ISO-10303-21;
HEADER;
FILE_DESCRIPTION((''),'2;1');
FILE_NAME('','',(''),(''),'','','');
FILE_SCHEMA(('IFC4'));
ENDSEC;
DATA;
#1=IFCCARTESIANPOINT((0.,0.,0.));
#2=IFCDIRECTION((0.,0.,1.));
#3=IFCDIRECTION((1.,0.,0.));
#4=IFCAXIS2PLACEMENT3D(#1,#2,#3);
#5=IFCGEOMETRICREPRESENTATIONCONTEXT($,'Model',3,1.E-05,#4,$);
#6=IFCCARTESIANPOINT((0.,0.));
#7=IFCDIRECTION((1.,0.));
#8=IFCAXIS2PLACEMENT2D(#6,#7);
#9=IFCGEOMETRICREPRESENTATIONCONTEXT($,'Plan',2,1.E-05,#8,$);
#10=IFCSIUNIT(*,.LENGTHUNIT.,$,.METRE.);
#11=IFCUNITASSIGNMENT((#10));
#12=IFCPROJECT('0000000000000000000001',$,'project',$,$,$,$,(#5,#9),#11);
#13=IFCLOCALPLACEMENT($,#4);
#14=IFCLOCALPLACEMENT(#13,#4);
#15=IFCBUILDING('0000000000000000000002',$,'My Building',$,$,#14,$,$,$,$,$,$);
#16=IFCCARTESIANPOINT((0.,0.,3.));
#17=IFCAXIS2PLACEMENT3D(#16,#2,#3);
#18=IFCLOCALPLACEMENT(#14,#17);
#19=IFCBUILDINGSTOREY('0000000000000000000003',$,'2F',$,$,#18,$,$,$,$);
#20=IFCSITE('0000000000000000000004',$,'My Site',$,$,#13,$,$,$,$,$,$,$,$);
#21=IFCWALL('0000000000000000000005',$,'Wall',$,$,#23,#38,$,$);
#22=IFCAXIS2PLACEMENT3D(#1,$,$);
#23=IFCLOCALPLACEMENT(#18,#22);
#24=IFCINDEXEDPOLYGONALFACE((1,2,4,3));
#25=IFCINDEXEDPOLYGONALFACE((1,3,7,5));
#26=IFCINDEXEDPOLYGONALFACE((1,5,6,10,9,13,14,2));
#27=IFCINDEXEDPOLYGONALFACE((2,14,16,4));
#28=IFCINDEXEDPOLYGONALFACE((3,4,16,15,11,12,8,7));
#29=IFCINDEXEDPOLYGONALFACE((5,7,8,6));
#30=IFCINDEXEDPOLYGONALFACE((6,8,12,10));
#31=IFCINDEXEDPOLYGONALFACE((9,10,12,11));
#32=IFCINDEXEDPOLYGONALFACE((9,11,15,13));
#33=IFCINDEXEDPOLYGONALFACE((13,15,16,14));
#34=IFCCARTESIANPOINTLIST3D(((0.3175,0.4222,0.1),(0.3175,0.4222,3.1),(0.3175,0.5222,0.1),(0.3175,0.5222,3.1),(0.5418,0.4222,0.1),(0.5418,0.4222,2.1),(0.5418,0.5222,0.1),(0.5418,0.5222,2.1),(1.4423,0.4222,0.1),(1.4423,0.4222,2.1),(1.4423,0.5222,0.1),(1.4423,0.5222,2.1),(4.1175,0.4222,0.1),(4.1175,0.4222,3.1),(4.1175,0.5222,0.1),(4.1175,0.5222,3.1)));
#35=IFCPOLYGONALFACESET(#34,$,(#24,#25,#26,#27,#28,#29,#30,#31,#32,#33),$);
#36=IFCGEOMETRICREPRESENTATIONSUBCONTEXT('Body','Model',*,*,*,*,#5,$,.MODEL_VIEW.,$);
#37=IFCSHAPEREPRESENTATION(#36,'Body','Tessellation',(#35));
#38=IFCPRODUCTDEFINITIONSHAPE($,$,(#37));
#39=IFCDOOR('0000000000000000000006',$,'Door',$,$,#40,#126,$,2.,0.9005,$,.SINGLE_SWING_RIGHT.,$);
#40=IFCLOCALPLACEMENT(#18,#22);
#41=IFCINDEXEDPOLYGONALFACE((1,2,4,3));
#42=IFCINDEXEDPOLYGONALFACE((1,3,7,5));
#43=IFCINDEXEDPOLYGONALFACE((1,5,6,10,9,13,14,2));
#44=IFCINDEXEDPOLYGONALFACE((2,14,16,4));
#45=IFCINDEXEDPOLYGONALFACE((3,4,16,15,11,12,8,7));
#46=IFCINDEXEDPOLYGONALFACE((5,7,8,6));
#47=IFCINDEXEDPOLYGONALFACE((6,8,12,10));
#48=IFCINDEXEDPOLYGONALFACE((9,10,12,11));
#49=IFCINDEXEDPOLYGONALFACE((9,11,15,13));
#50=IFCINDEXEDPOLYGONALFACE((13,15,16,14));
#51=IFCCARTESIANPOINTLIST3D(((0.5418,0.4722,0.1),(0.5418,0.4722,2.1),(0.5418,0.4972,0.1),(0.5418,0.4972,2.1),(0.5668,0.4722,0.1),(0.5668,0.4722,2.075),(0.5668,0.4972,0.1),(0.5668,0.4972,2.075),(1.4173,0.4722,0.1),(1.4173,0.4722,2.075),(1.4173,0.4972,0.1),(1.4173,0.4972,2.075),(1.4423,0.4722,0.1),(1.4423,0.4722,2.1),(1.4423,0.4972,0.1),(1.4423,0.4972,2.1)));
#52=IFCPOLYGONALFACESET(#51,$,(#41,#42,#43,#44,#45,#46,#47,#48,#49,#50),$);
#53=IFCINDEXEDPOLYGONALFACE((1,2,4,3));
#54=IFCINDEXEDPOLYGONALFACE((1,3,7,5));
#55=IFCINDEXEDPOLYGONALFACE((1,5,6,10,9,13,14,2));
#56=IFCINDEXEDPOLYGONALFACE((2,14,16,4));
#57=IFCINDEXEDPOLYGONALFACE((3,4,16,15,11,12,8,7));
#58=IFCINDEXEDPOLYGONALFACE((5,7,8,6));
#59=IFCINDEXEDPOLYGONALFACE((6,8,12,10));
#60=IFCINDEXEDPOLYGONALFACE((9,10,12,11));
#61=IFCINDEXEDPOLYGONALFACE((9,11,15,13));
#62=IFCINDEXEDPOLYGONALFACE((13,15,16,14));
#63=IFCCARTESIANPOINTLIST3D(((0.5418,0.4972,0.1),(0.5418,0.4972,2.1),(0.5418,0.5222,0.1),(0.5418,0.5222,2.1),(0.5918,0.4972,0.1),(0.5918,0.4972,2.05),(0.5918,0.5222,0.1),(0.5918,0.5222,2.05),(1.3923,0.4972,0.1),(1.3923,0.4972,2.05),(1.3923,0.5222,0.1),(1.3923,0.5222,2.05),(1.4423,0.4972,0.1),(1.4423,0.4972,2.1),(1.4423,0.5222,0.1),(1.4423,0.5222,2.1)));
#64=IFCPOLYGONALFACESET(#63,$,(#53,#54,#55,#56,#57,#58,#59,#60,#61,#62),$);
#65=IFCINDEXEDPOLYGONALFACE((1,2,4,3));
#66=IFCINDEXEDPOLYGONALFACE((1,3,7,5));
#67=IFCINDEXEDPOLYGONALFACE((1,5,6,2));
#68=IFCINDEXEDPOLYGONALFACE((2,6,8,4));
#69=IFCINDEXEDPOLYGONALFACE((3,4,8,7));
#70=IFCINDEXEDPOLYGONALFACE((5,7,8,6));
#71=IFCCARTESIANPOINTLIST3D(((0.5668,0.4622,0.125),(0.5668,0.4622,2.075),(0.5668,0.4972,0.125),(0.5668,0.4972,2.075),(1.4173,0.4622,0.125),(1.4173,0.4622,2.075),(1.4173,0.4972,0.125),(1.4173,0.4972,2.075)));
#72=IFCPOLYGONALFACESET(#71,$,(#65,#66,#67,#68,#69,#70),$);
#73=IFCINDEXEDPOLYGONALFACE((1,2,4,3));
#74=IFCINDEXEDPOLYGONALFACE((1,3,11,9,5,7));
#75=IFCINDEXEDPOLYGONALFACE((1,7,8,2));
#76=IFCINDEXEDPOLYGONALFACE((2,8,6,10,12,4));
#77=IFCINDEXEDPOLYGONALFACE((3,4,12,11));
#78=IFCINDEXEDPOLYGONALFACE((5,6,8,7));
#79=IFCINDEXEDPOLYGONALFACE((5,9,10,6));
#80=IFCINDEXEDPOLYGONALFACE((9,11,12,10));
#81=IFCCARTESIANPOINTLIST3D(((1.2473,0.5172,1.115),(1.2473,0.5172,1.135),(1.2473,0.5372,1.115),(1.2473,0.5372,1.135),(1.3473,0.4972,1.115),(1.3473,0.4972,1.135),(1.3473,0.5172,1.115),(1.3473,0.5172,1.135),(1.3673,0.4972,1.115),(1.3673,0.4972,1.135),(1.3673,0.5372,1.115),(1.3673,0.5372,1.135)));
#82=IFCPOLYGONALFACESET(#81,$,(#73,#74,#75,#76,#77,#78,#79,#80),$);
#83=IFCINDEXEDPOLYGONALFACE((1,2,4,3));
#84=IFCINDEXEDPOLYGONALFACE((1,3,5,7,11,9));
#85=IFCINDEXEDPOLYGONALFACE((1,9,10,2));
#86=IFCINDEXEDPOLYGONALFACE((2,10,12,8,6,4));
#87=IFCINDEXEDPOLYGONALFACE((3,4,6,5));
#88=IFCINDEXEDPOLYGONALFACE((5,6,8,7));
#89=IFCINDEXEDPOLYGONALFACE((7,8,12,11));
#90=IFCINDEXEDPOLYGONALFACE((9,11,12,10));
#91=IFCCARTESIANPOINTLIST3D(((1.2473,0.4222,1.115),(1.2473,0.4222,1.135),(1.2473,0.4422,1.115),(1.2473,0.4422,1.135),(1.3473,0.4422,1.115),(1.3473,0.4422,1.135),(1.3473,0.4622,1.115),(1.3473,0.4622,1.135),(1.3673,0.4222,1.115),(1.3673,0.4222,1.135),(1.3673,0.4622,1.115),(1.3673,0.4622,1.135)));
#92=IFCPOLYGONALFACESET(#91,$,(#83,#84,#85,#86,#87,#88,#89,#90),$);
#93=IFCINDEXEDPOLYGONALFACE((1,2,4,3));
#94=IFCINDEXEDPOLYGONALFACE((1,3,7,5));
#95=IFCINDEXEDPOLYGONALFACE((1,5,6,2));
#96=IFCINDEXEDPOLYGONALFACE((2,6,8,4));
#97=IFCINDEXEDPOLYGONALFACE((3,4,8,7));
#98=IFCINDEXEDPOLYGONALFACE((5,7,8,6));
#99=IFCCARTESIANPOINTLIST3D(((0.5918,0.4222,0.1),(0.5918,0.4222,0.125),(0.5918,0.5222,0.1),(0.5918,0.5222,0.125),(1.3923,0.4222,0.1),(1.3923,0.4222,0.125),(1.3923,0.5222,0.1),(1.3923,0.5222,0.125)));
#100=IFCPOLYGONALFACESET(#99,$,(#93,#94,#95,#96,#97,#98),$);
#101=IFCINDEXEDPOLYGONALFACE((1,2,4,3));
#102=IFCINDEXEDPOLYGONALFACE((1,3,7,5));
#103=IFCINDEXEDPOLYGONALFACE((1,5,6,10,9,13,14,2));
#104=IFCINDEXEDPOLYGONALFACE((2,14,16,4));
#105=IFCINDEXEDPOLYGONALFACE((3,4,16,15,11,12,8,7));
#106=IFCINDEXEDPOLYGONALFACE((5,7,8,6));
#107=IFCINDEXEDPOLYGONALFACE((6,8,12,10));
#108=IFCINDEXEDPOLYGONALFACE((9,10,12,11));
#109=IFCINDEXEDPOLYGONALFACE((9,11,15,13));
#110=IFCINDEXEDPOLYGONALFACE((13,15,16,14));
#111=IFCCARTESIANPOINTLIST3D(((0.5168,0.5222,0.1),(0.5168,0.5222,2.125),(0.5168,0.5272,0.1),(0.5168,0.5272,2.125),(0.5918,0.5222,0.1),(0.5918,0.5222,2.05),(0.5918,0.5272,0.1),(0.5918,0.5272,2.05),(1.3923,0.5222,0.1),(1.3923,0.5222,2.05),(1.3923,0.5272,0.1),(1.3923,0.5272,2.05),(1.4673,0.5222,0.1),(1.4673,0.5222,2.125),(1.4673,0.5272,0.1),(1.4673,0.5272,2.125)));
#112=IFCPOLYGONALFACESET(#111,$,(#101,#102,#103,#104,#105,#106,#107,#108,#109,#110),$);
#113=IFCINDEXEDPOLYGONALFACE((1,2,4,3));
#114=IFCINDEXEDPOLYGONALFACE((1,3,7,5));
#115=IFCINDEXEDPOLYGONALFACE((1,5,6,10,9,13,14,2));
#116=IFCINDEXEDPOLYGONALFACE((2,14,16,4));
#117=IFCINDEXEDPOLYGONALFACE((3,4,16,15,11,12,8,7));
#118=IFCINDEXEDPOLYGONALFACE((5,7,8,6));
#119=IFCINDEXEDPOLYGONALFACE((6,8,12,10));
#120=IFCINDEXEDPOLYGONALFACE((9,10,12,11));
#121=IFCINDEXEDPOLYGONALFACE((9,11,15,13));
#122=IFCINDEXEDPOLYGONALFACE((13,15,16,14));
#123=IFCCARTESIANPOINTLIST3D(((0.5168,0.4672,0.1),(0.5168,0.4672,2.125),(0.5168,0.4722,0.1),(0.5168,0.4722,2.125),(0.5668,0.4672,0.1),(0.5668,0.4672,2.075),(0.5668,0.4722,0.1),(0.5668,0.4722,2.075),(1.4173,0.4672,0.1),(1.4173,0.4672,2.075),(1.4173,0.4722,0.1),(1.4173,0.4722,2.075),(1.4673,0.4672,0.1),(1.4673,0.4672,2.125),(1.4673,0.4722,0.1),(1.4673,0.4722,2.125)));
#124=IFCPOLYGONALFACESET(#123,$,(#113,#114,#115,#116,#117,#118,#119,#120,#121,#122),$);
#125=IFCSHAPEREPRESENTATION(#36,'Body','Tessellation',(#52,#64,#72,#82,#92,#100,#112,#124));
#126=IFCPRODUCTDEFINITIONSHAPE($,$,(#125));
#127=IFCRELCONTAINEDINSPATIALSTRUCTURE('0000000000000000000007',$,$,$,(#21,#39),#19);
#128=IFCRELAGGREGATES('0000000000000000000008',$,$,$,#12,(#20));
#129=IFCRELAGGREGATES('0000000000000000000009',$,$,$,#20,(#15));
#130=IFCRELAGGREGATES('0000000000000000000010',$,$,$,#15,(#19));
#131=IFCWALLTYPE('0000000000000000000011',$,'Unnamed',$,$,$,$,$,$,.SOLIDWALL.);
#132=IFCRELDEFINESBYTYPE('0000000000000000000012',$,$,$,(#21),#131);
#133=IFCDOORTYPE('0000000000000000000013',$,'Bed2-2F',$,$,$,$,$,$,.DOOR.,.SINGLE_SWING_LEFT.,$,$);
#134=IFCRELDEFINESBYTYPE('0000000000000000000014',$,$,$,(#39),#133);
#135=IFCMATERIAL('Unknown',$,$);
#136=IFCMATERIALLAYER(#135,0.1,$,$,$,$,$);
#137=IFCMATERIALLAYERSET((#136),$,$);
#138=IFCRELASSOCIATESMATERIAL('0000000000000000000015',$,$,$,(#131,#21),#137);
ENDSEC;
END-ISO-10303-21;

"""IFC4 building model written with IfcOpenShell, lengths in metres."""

from ifc_helpers import new_model, entity, si_unit, frame, origin_with_axes, origin_2d_with_axis, place, context, subcontext, project, spatial, line, indexed_curve, outline, extrude, shape, source, transform, mapped, material, layer, layer_set, layer_usage, type_object, type_shapes, element, fill, save


model = new_model("IFC4")

# Units and contexts
model_context = context("Model", 3, precision=1e-05, world=origin_with_axes())
plan_context = context("Plan", 2, precision=1e-05, world=origin_2d_with_axis())
body_context_1 = subcontext(model_context, "Body", "Model", "MODEL_VIEW")
body_context_2 = subcontext(plan_context, "Body", "Plan", "PLAN_VIEW")
ifc_project = project(units=[si_unit("LENGTHUNIT", "METRE")], contexts=[model_context, plan_context])

# Site, building, storey
site_placement = place(None, origin_with_axes())
site = spatial("IfcSite", under=ifc_project, at=site_placement, Name="My Site")
building_placement = place(site_placement, origin_with_axes())
building = spatial("IfcBuilding", under=site, at=building_placement, Name="My Building")
storey_placement = place(building_placement, frame((0.0, 0.0, 3.0), z_axis=(0.0, 0.0, 1.0), x_axis=(1.0, 0.0, 0.0)))
storey = spatial("IfcBuildingStorey", under=building, at=storey_placement, Name="2F")

# Shared definitions
ifc_material = material(Name="Unknown")
ifc_layer = layer(ifc_material, 0.1)
ifc_layer_set = layer_set([ifc_layer])
wall_type = type_object("IfcWallType", Name="Unnamed", PredefinedType="SOLIDWALL", material=ifc_layer_set)

# Wall, opening, door
ifc_layer_usage_1 = layer_usage(ifc_layer_set, "AXIS2", "POSITIVE", 0.0)
wall_1_placement = place(storey_placement, frame((0.2175, 0.4222, 0.1), z_axis=(0.0, 0.0, 1.0), x_axis=(1.0, 0.0, 0.0)))
wall_1 = element("IfcWall", 1, at=wall_1_placement, inside=storey, type_object=wall_type, material=ifc_layer_usage_1, Name="Wall", context=body_context_1, shape_type="SweptSolid", body=[
    extrude(outline(indexed_curve([(0.1, 0.0), (0.1, 0.1), (3.9, 0.1), (3.9, 0.0)], segments=[line(1, 2, 3, 4, 1)])), origin_with_axes(), (0.0, 0.0, 1.0), 3.0),
])
shared_shape_1 = source(origin_with_axes(), body_context_1, "Body", "SweptSolid", [
    extrude(outline(indexed_curve([(0.0, 0.0), (0.9005, 0.0), (0.9005, 2.0), (0.0, 2.0)], segments=[line(1, 2, 3, 4, 1)])), frame((0.0, -0.6, 0.0), z_axis=(0.0, -1.0, 0.0), x_axis=(1.0, 0.0, 0.0)), (0.0, 0.0, -1.0), 1.2),
])
opening_1_placement = place(wall_1_placement, frame((1.2248, 0.1, 0.0), z_axis=(0.0, 0.0, 1.0), x_axis=(-1.0, 0.0, 0.0)))
opening_1 = element("IfcOpeningElement", 2, at=opening_1_placement, cuts=wall_1, PredefinedType="OPENING", context=body_context_1, shape_type="MappedRepresentation", body=[
    mapped(shared_shape_1, transform((0.0, 0.0, 0.0), x_axis=(1.0, 0.0, 0.0), y_axis=(0.0, 1.0, 0.0), z_axis=(0.0, 0.0, 1.0), scale=1.0)),
])
door_type_1 = type_object("IfcDoorType", Name="Bed2-2F", OperationType="SINGLE_SWING_LEFT", PredefinedType="DOOR")
shared_shape_2 = source(origin_with_axes(), body_context_1, "Body", "SweptSolid", [
    extrude(outline(indexed_curve([(0.0, 0.0), (0.0, 2.0), (0.9005, 2.0), (0.9005, 0.0), (0.8755, 0.0), (0.8755, 1.975), (0.025, 1.975), (0.025, 0.0)], segments=[line(1, 2, 3, 4, 5, 6, 7, 8, 1)])), frame((0.0, 0.025, 0.0), z_axis=(0.0, -1.0, 0.0), x_axis=(1.0, 0.0, 0.0)), (0.0, 0.0, -1.0), 0.025),
    extrude(outline(indexed_curve([(0.0, 0.0), (0.0, 2.0), (0.9005, 2.0), (0.9005, 0.0), (0.8505, 0.0), (0.8505, 1.95), (0.05, 1.95), (0.05, 0.0)], segments=[line(1, 2, 3, 4, 5, 6, 7, 8, 1)])), frame((0.0, 0.0, 0.0), z_axis=(0.0, -1.0, 0.0), x_axis=(1.0, 0.0, 0.0)), (0.0, 0.0, -1.0), 0.025),
    extrude(outline(indexed_curve([(0.0, 0.0), (0.8505, 0.0), (0.8505, 0.035), (0.0, 0.035)], segments=[line(1, 2, 3, 4, 1)])), frame((0.025, 0.025, 0.025), z_axis=(0.0, 0.0, 1.0), x_axis=(1.0, 0.0, 0.0)), (0.0, 0.0, 1.0), 1.95),
    extrude(outline(indexed_curve([(0.0, 0.0), (0.0, -0.04), (0.12, -0.04), (0.12, -0.02), (0.02, -0.02), (0.02, 0.0)], segments=[line(1, 2, 3, 4, 5, 6, 1)])), frame((0.075, 0.025, 1.015), z_axis=(0.0, 0.0, 1.0), x_axis=(1.0, 0.0, 0.0)), (0.0, 0.0, 1.0), 0.02),
    extrude(outline(indexed_curve([(0.0, 0.0), (0.0, 0.04), (0.12, 0.04), (0.12, 0.02), (0.02, 0.02), (0.02, 0.0)], segments=[line(1, 2, 3, 4, 5, 6, 1)])), frame((0.075, 0.06, 1.015), z_axis=(0.0, 0.0, 1.0), x_axis=(1.0, 0.0, 0.0)), (0.0, 0.0, 1.0), 0.02),
    extrude(outline(indexed_curve([(0.0, 0.0), (0.8005, 0.0), (0.8005, 0.1), (0.0, 0.1)], segments=[line(1, 2, 3, 4, 1)])), frame((0.05, 0.0, 0.0), z_axis=(0.0, 0.0, 1.0), x_axis=(1.0, 0.0, 0.0)), (0.0, 0.0, 1.0), 0.025),
    extrude(outline(indexed_curve([(0.0, 0.0), (0.0, 2.025), (0.9505, 2.025), (0.9505, 0.0), (0.8755, 0.0), (0.8755, 1.95), (0.075, 1.95), (0.075, 0.0)], segments=[line(1, 2, 3, 4, 5, 6, 7, 8, 1)])), frame((-0.025, -0.005, 0.0), z_axis=(0.0, -1.0, 0.0), x_axis=(1.0, 0.0, 0.0)), (0.0, 0.0, -1.0), 0.005),
    extrude(outline(indexed_curve([(0.0, 0.0), (0.0, 2.025), (0.9505, 2.025), (0.9505, 0.0), (0.9005, 0.0), (0.9005, 1.975), (0.05, 1.975), (0.05, 0.0)], segments=[line(1, 2, 3, 4, 5, 6, 7, 8, 1)])), frame((-0.025, 0.05, 0.0), z_axis=(0.0, -1.0, 0.0), x_axis=(1.0, 0.0, 0.0)), (0.0, 0.0, -1.0), 0.005),
])
shared_shape_3 = source(origin_with_axes(), body_context_2, "Body", "Curve2D", [
    entity("IfcIndexedPolyCurve", entity("IfcCartesianPointList2D", [[0.0, 0.0], [0.0, 0.05], [0.025, 0.05], [0.025, 0.025], [0.05, 0.025], [0.05, 0.0]]), [entity("IfcLineIndex", [1, 2, 3, 4, 5, 6, 1])]),
    entity("IfcIndexedPolyCurve", entity("IfcCartesianPointList2D", [[0.9005, 0.0], [0.9005, 0.05], [0.8755, 0.05], [0.8755, 0.025], [0.8505, 0.025], [0.8505, 0.0]]), [entity("IfcLineIndex", [1, 2, 3, 4, 5, 6, 1])]),
    entity("IfcTrimmedCurve", entity("IfcEllipse", entity("IfcAxis2Placement2D", entity("IfcCartesianPoint", [0.8405, 0.05]), entity("IfcDirection", [1.0, 0.0])), 0.8155, 0.8505), [entity("IfcCartesianPoint", [0.8405, 0.9005])], [entity("IfcCartesianPoint", [0.025, 0.05])], True, "CARTESIAN"),
    entity("IfcIndexedPolyCurve", entity("IfcCartesianPointList2D", [[0.8755, 0.05], [0.8405, 0.05], [0.8405, 0.9005], [0.8755, 0.9005]]), [entity("IfcLineIndex", [1, 2, 3, 4, 1])]),
])
type_shapes(door_type_1, [shared_shape_2, shared_shape_3])
door_1_placement = place(opening_1_placement, frame((0.0, 0.0, 0.0), z_axis=(0.0, 0.0, 1.0), x_axis=(1.0, 0.0, 0.0)))
door_1 = element("IfcDoor", 3, at=door_1_placement, inside=storey, type_object=door_type_1, Name="Door", OperationType="SINGLE_SWING_RIGHT", OverallHeight=2.0, OverallWidth=0.9005, shapes=[
    shape(body_context_1, "Body", "MappedRepresentation", [mapped(shared_shape_2, transform((0.0, 0.0, 0.0), x_axis=(1.0, 0.0, 0.0), y_axis=(0.0, 1.0, 0.0), z_axis=(0.0, 0.0, 1.0), scale=1.0))]),
    shape(body_context_2, "Body", "MappedRepresentation", [mapped(shared_shape_3, transform((0.0, 0.0, 0.0), x_axis=(1.0, 0.0, 0.0), y_axis=(0.0, 1.0, 0.0), z_axis=(0.0, 0.0, 1.0), scale=1.0))]),
])
fill(opening_1, door_1)

save(model, "model.ifc")
